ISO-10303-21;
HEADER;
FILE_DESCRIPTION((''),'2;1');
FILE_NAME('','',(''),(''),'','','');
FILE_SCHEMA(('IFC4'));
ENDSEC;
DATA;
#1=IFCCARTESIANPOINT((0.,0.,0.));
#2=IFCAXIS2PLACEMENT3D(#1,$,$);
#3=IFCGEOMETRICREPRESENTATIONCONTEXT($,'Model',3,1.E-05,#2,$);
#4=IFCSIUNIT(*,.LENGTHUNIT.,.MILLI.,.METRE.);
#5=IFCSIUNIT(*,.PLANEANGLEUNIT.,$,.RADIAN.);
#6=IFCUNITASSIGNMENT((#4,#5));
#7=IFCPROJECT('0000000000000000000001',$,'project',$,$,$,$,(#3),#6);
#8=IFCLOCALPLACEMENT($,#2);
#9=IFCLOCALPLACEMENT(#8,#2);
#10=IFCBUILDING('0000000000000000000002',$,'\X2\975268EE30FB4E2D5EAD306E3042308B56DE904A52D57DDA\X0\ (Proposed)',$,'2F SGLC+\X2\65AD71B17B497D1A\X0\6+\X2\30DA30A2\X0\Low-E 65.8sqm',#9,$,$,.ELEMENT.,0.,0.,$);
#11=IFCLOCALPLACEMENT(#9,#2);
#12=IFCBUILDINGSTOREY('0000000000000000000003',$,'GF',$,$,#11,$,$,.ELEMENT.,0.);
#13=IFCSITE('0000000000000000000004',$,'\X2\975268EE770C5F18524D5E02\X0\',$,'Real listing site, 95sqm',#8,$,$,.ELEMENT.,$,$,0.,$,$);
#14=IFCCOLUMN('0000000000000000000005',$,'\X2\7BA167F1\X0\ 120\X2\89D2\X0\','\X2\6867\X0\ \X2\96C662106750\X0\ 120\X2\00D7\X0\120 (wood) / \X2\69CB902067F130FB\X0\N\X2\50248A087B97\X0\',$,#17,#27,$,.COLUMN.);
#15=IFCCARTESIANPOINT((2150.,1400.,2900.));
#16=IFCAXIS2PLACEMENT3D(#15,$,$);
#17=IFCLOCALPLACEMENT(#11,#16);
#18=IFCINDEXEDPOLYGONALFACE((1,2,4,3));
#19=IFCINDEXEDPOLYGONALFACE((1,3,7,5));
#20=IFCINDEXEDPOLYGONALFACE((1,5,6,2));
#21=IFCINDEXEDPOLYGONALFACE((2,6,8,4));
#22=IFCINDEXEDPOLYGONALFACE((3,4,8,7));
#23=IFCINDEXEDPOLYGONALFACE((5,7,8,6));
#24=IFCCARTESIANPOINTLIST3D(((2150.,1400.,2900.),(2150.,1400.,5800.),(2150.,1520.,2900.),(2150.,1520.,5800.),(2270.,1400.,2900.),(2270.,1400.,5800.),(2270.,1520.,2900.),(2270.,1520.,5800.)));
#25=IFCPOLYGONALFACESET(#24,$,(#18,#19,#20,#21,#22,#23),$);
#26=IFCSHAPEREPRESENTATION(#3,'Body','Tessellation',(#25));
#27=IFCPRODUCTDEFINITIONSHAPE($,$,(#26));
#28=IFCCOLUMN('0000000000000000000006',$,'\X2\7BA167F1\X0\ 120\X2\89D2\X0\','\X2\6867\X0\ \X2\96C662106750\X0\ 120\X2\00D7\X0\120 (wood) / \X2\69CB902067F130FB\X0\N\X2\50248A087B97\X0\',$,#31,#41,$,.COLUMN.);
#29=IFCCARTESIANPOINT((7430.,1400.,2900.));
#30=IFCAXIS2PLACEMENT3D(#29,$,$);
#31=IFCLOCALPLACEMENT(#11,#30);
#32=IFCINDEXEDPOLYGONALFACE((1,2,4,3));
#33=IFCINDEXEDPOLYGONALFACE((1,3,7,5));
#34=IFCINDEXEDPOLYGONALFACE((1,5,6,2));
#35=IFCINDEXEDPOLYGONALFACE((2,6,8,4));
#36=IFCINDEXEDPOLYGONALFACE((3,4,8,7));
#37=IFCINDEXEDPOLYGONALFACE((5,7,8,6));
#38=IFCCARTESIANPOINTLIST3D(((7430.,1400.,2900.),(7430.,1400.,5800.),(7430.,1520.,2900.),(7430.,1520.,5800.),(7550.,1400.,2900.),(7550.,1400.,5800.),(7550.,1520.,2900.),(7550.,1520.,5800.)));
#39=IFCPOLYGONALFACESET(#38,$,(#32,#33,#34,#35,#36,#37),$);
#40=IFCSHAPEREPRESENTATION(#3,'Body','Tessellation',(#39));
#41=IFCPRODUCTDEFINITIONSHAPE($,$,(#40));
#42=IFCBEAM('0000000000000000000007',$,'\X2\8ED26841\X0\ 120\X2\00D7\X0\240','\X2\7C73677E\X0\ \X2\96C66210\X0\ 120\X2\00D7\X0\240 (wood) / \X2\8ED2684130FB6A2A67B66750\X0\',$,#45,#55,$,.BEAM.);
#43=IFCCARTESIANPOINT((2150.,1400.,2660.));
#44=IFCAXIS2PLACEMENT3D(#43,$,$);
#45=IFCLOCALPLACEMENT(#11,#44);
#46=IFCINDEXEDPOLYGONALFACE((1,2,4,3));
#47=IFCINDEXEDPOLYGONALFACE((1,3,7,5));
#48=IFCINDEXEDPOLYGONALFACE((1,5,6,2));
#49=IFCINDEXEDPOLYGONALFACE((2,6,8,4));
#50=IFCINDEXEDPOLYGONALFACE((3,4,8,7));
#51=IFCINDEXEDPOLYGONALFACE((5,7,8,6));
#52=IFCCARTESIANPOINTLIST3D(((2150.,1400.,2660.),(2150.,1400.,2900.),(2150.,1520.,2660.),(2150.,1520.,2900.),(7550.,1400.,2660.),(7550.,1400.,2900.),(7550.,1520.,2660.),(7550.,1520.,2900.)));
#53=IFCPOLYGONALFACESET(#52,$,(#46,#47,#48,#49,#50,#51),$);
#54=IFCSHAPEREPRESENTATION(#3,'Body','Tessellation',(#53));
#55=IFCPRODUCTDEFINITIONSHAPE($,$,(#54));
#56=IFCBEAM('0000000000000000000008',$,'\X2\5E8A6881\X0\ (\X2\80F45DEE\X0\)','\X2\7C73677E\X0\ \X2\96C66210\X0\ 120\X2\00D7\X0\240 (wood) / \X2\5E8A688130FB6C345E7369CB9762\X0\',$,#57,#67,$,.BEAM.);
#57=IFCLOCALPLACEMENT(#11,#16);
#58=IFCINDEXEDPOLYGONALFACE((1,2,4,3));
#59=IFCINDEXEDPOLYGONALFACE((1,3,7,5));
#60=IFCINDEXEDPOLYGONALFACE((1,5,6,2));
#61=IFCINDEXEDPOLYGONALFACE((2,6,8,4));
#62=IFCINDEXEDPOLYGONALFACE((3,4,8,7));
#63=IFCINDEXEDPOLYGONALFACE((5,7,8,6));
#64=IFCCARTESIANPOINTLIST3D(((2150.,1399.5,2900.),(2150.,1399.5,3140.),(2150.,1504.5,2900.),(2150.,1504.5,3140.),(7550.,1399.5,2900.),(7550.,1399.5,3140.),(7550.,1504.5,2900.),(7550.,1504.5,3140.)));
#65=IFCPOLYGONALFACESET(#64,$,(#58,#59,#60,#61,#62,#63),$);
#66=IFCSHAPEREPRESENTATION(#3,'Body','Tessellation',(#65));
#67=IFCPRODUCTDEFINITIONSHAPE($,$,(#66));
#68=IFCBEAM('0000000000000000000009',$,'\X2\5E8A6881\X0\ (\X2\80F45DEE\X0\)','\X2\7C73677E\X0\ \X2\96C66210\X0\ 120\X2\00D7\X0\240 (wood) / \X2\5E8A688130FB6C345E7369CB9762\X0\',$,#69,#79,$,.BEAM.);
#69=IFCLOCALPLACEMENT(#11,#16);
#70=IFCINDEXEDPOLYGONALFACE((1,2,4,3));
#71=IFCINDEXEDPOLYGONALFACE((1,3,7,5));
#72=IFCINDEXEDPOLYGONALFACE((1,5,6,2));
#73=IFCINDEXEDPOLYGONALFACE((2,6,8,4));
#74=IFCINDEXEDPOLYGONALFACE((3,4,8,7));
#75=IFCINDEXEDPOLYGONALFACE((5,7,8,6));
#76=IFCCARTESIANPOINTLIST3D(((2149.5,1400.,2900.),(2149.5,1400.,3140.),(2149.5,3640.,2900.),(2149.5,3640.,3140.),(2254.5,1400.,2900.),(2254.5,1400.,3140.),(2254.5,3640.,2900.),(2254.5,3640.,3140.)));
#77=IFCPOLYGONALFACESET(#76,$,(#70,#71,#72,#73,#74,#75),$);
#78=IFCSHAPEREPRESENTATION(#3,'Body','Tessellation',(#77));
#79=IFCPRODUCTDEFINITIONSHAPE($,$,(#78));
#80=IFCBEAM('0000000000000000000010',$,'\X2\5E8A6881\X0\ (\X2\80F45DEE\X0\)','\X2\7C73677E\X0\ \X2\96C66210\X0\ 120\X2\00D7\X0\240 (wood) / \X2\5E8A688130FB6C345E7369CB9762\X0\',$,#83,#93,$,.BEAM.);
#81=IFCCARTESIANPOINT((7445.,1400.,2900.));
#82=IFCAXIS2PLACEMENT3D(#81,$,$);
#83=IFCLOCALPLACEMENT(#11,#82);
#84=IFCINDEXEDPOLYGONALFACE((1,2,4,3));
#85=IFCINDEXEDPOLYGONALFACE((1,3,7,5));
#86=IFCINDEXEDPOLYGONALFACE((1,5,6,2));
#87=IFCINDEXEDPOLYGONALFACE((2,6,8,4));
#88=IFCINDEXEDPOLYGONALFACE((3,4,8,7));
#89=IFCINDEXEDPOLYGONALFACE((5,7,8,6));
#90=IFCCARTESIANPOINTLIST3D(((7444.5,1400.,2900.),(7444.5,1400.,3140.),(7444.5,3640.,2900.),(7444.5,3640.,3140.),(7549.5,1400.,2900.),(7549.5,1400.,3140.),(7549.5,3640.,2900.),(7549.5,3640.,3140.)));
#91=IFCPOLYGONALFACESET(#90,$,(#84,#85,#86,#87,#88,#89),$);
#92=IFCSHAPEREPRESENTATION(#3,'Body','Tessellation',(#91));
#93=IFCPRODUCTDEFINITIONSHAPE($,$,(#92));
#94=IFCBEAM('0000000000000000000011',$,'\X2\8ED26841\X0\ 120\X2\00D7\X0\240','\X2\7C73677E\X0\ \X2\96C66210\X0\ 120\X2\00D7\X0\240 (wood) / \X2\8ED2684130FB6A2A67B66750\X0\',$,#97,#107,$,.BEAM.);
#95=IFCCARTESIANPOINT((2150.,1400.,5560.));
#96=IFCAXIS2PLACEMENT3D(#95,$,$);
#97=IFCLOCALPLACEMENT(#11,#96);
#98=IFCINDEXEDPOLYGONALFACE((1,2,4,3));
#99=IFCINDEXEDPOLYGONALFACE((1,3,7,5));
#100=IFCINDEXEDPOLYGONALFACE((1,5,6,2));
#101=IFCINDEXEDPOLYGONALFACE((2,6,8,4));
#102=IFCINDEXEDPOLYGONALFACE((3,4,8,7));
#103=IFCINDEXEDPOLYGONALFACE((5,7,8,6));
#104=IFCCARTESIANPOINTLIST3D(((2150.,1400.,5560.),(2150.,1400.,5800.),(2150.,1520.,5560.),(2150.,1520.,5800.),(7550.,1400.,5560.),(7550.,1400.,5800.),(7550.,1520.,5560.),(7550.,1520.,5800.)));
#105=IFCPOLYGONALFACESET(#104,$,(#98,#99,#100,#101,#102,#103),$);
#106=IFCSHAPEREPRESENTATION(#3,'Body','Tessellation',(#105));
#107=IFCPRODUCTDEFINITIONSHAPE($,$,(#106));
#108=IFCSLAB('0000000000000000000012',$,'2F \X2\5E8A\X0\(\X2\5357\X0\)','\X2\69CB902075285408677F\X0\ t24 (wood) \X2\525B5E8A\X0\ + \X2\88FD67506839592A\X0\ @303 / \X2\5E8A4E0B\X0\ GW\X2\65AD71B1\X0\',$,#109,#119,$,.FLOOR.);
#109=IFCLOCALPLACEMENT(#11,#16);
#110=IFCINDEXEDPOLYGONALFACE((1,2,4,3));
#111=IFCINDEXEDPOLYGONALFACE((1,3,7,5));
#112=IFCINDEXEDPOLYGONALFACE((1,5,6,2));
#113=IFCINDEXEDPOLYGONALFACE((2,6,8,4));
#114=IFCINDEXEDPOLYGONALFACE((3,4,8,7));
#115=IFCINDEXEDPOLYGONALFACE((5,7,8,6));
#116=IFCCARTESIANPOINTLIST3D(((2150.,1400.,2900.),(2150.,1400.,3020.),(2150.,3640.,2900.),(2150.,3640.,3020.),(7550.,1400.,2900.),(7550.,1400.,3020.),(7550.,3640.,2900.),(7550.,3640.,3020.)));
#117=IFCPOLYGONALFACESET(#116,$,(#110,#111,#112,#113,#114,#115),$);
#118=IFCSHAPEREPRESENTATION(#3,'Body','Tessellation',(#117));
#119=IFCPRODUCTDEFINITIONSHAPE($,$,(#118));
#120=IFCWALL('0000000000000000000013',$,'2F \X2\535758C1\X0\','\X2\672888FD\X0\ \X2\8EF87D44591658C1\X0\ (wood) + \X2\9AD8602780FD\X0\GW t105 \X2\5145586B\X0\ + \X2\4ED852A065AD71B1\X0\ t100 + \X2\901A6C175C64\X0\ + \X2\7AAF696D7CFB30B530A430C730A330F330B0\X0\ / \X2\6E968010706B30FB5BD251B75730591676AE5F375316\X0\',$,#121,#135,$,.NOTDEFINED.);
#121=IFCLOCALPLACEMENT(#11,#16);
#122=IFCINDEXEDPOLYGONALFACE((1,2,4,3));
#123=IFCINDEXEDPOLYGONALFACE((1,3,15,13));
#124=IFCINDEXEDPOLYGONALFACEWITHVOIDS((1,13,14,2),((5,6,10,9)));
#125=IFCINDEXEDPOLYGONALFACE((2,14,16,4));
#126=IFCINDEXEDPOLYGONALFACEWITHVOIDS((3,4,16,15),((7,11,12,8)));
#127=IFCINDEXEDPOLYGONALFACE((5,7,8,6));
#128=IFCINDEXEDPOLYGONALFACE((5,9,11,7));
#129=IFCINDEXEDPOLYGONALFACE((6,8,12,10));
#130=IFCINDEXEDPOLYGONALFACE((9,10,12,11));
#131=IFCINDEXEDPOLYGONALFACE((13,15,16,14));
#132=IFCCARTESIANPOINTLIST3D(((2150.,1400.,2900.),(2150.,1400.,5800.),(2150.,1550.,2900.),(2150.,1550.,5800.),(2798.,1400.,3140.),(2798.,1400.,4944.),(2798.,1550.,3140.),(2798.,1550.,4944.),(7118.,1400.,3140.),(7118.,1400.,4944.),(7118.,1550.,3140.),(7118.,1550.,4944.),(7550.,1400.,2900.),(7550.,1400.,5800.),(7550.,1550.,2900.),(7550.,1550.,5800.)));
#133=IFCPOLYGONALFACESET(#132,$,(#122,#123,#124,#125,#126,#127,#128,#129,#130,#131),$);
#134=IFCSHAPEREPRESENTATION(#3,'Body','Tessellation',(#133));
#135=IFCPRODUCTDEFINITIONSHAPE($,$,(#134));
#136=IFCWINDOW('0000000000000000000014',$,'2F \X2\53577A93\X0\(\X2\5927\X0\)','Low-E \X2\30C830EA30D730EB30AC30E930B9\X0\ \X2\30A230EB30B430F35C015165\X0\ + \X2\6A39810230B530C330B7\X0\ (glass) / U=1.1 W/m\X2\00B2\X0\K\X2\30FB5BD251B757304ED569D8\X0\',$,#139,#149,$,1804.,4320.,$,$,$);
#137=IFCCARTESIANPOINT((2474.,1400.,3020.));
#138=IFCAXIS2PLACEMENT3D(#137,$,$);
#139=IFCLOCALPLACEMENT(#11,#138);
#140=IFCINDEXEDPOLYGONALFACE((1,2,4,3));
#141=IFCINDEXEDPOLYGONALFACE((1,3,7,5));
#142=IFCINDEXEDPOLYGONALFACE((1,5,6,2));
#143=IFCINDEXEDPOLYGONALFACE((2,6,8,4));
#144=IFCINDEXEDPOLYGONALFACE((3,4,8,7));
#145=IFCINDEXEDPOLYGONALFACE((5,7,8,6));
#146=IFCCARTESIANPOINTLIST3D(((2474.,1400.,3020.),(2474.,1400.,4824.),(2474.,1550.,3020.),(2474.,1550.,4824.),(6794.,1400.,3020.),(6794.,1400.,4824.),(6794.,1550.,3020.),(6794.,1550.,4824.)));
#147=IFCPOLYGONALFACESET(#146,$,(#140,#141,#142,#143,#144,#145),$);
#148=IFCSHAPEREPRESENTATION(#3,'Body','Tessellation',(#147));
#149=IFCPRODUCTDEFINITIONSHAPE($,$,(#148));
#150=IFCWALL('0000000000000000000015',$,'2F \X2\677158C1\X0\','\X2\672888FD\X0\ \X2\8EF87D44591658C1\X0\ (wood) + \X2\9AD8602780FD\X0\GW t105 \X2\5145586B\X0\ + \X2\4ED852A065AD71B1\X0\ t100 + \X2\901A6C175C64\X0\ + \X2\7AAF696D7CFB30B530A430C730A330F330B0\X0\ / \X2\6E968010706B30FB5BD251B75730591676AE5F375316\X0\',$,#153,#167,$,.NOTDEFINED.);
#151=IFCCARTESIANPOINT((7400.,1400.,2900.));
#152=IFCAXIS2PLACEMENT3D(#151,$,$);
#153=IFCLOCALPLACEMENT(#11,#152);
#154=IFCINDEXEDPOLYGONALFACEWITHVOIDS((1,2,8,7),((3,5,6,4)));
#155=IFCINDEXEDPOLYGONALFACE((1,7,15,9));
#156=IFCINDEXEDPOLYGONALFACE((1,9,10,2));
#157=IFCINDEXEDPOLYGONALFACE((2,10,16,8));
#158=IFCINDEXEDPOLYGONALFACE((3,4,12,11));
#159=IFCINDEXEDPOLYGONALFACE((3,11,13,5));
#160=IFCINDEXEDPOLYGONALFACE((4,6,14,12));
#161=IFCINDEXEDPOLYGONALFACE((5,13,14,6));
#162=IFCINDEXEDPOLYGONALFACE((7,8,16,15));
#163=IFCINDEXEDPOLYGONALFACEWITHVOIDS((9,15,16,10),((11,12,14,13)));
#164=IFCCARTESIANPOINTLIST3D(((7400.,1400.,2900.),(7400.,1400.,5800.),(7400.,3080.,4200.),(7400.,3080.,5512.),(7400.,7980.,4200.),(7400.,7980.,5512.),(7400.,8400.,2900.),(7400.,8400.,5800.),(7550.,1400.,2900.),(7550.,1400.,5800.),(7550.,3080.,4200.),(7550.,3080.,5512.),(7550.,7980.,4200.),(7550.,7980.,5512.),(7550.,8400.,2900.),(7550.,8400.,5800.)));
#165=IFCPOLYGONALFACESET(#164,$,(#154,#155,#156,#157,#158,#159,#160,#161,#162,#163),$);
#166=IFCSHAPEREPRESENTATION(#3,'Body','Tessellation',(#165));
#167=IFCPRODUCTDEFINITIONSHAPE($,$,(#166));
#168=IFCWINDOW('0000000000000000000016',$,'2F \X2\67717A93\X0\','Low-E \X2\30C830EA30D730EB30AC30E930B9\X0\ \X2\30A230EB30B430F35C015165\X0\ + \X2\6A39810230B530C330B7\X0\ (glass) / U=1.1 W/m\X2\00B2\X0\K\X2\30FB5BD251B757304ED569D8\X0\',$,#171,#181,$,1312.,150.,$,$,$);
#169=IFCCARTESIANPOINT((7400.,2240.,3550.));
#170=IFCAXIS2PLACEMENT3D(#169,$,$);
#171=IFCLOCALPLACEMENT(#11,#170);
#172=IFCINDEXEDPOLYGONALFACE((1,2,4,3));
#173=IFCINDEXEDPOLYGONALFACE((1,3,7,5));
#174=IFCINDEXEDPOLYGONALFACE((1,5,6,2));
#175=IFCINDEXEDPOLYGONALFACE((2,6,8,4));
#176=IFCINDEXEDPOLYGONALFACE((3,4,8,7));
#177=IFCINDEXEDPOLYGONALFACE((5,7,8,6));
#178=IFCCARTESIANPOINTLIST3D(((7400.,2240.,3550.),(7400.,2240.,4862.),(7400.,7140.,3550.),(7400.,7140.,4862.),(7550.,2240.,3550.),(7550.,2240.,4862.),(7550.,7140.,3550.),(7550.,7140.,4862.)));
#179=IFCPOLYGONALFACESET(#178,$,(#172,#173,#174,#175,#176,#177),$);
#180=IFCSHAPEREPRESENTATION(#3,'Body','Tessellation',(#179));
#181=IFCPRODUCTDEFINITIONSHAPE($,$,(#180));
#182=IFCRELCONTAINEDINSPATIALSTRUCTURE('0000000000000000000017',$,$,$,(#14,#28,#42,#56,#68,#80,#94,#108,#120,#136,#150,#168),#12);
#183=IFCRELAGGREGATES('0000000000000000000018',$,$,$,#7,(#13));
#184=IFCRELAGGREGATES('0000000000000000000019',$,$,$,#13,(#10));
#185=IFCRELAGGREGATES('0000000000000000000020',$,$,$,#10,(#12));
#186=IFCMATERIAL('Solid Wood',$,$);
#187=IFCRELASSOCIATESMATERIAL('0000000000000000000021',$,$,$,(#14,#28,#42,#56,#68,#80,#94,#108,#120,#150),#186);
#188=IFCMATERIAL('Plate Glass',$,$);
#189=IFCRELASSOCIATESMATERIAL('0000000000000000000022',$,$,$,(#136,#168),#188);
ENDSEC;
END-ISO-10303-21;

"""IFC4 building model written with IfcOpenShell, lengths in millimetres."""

from ifc_helpers import new_model, si_unit, frame, frame_2d, origin, place, context, project, spatial, rectangle, extrude, material, element, fill, save


model = new_model("IFC4")

# Units and contexts
model_context = context("Model", 3, precision=1e-05, world=origin())
ifc_project = project(units=[si_unit("LENGTHUNIT", "METRE", prefix="MILLI"), si_unit("PLANEANGLEUNIT", "RADIAN")], contexts=[model_context])

# Site, building, storey
site_placement = place(None, origin())
site = spatial("IfcSite", under=ifc_project, at=site_placement, Name="青森県弘前市", ObjectType="Real listing site, 95sqm", CompositionType="ELEMENT", RefElevation=0.0)
building_placement = place(site_placement, origin())
building = spatial("IfcBuilding", under=site, at=building_placement, Name="青森・中庭のある回遊動線 (Proposed)", ObjectType="2F SGLC+断熱等級6+ペアLow-E 65.8sqm", CompositionType="ELEMENT", ElevationOfRefHeight=0.0, ElevationOfTerrain=0.0)
storey_placement = place(building_placement, origin())
storey = spatial("IfcBuildingStorey", under=building, at=storey_placement, Name="GF", CompositionType="ELEMENT", Elevation=0.0)

# Columns
ifc_material_1 = material(Name="Solid Wood")
column_1_placement = place(storey_placement, frame((2150.0, 1400.0, 2900.0)))
element("IfcColumn", 1, at=column_1_placement, inside=storey, material=ifc_material_1, Name="管柱 120角", Description="桧 集成材 120×120 (wood) / 構造柱・N値計算", PredefinedType="COLUMN", context=model_context, shape_type="SweptSolid", body=[
    extrude(rectangle(XDim=120.0, YDim=120.0, at=frame_2d((60.0, 60.0))), frame((2150.0, 1400.0, 2900.0)), (0.0, 0.0, 1.0), 2900.0),
])
column_2_placement = place(storey_placement, frame((7430.0, 1400.0, 2900.0)))
element("IfcColumn", 2, at=column_2_placement, inside=storey, material=ifc_material_1, Name="管柱 120角", Description="桧 集成材 120×120 (wood) / 構造柱・N値計算", PredefinedType="COLUMN", context=model_context, shape_type="SweptSolid", body=[
    extrude(rectangle(XDim=120.0, YDim=120.0, at=frame_2d((60.0, 60.0))), frame((7430.0, 1400.0, 2900.0)), (0.0, 0.0, 1.0), 2900.0),
])

# Beams
beam_1_placement = place(storey_placement, frame((2150.0, 1400.0, 2660.0)))
element("IfcBeam", 3, at=beam_1_placement, inside=storey, material=ifc_material_1, Name="軒桁 120×240", Description="米松 集成 120×240 (wood) / 軒桁・横架材", PredefinedType="BEAM", context=model_context, shape_type="SweptSolid", body=[
    extrude(rectangle(XDim=5400.0, YDim=120.0, at=frame_2d((2700.0, 60.0))), frame((2150.0, 1400.0, 2660.0)), (0.0, 0.0, 1.0), 240.0),
])
beam_2_placement = place(storey_placement, frame((2150.0, 1400.0, 2900.0)))
element("IfcBeam", 4, at=beam_2_placement, inside=storey, material=ifc_material_1, Name="床梁 (胴差)", Description="米松 集成 120×240 (wood) / 床梁・水平構面", PredefinedType="BEAM", context=model_context, shape_type="SweptSolid", body=[
    extrude(rectangle(XDim=5400.0, YDim=105.0, at=frame_2d((2700.0, 52.0))), frame((2150.0, 1400.0, 2900.0)), (0.0, 0.0, 1.0), 240.0),
])
beam_3_placement = place(storey_placement, frame((2150.0, 1400.0, 2900.0)))
element("IfcBeam", 5, at=beam_3_placement, inside=storey, material=ifc_material_1, Name="床梁 (胴差)", Description="米松 集成 120×240 (wood) / 床梁・水平構面", PredefinedType="BEAM", context=model_context, shape_type="SweptSolid", body=[
    extrude(rectangle(XDim=105.0, YDim=2240.0, at=frame_2d((52.0, 1120.0))), frame((2150.0, 1400.0, 2900.0)), (0.0, 0.0, 1.0), 240.0),
])
beam_4_placement = place(storey_placement, frame((7445.0, 1400.0, 2900.0)))
element("IfcBeam", 6, at=beam_4_placement, inside=storey, material=ifc_material_1, Name="床梁 (胴差)", Description="米松 集成 120×240 (wood) / 床梁・水平構面", PredefinedType="BEAM", context=model_context, shape_type="SweptSolid", body=[
    extrude(rectangle(XDim=105.0, YDim=2240.0, at=frame_2d((52.0, 1120.0))), frame((7445.0, 1400.0, 2900.0)), (0.0, 0.0, 1.0), 240.0),
])
beam_5_placement = place(storey_placement, frame((2150.0, 1400.0, 5560.0)))
element("IfcBeam", 7, at=beam_5_placement, inside=storey, material=ifc_material_1, Name="軒桁 120×240", Description="米松 集成 120×240 (wood) / 軒桁・横架材", PredefinedType="BEAM", context=model_context, shape_type="SweptSolid", body=[
    extrude(rectangle(XDim=5400.0, YDim=120.0, at=frame_2d((2700.0, 60.0))), frame((2150.0, 1400.0, 5560.0)), (0.0, 0.0, 1.0), 240.0),
])

# Slab
slab_placement = place(storey_placement, frame((2150.0, 1400.0, 2900.0)))
element("IfcSlab", 8, at=slab_placement, inside=storey, material=ifc_material_1, Name="2F 床(南)", Description="構造用合板 t24 (wood) 剛床 + 製材根太 @303 / 床下 GW断熱", PredefinedType="FLOOR", context=model_context, shape_type="SweptSolid", body=[
    extrude(rectangle(XDim=5400.0, YDim=2240.0, at=frame_2d((2700.0, 1120.0))), frame((2150.0, 1400.0, 2900.0)), (0.0, 0.0, 1.0), 120.0),
])

# Walls, openings, windows
wall_1_placement = place(storey_placement, frame((2150.0, 1400.0, 2900.0)))
wall_1 = element("IfcWall", 9, at=wall_1_placement, inside=storey, material=ifc_material_1, Name="2F 南壁", Description="木製 軸組外壁 (wood) + 高性能GW t105 充填 + 付加断熱 t100 + 通気層 + 窯業系サイディング / 準耐火・寒冷地外皮強化", PredefinedType="NOTDEFINED", context=model_context, shape_type="SweptSolid", body=[
    extrude(rectangle(XDim=5400.0, YDim=150.0, at=frame_2d((2700.0, 75.0))), frame((2150.0, 1400.0, 2900.0)), (0.0, 0.0, 1.0), 2900.0),
])
opening_1_placement = place(storey_placement, frame((2474.0, 1400.0, 3020.0)))
opening_1 = element("IfcOpeningElement", 10, at=opening_1_placement, cuts=wall_1, PredefinedType="NOTDEFINED", context=model_context, shape_type="SweptSolid", body=[
    extrude(rectangle(XDim=4320.0, YDim=150.0, at=frame_2d((2160.0, 75.0))), frame((2474.0, 1400.0, 3020.0)), (0.0, 0.0, 1.0), 1804.0),
])
ifc_material_2 = material(Name="Plate Glass")
window_1_placement = place(storey_placement, frame((2474.0, 1400.0, 3020.0)))
window_1 = element("IfcWindow", 11, at=window_1_placement, inside=storey, material=ifc_material_2, Name="2F 南窓(大)", Description="Low-E トリプルガラス アルゴン封入 + 樹脂サッシ (glass) / U=1.1 W/m²K・寒冷地仕様", OverallHeight=1804.0, OverallWidth=4320.0, context=model_context, shape_type="SweptSolid", body=[
    extrude(rectangle(XDim=4320.0, YDim=150.0, at=frame_2d((2160.0, 75.0))), frame((2474.0, 1400.0, 3020.0)), (0.0, 0.0, 1.0), 1804.0),
])
fill(opening_1, window_1)
wall_2_placement = place(storey_placement, frame((7400.0, 1400.0, 2900.0)))
wall_2 = element("IfcWall", 12, at=wall_2_placement, inside=storey, material=ifc_material_1, Name="2F 東壁", Description="木製 軸組外壁 (wood) + 高性能GW t105 充填 + 付加断熱 t100 + 通気層 + 窯業系サイディング / 準耐火・寒冷地外皮強化", PredefinedType="NOTDEFINED", context=model_context, shape_type="SweptSolid", body=[
    extrude(rectangle(XDim=150.0, YDim=7000.0, at=frame_2d((75.0, 3500.0))), frame((7400.0, 1400.0, 2900.0)), (0.0, 0.0, 1.0), 2900.0),
])
opening_2_placement = place(storey_placement, frame((7400.0, 2240.0, 3550.0)))
opening_2 = element("IfcOpeningElement", 13, at=opening_2_placement, cuts=wall_2, PredefinedType="NOTDEFINED", context=model_context, shape_type="SweptSolid", body=[
    extrude(rectangle(XDim=150.0, YDim=4900.0, at=frame_2d((75.0, 2450.0))), frame((7400.0, 2240.0, 3550.0)), (0.0, 0.0, 1.0), 1312.0),
])
window_2_placement = place(storey_placement, frame((7400.0, 2240.0, 3550.0)))
window_2 = element("IfcWindow", 14, at=window_2_placement, inside=storey, material=ifc_material_2, Name="2F 東窓", Description="Low-E トリプルガラス アルゴン封入 + 樹脂サッシ (glass) / U=1.1 W/m²K・寒冷地仕様", OverallHeight=1312.0, OverallWidth=150.0, context=model_context, shape_type="SweptSolid", body=[
    extrude(rectangle(XDim=150.0, YDim=4900.0, at=frame_2d((75.0, 2450.0))), frame((7400.0, 2240.0, 3550.0)), (0.0, 0.0, 1.0), 1312.0),
])
fill(opening_2, window_2)

save(model, "model.ifc")
